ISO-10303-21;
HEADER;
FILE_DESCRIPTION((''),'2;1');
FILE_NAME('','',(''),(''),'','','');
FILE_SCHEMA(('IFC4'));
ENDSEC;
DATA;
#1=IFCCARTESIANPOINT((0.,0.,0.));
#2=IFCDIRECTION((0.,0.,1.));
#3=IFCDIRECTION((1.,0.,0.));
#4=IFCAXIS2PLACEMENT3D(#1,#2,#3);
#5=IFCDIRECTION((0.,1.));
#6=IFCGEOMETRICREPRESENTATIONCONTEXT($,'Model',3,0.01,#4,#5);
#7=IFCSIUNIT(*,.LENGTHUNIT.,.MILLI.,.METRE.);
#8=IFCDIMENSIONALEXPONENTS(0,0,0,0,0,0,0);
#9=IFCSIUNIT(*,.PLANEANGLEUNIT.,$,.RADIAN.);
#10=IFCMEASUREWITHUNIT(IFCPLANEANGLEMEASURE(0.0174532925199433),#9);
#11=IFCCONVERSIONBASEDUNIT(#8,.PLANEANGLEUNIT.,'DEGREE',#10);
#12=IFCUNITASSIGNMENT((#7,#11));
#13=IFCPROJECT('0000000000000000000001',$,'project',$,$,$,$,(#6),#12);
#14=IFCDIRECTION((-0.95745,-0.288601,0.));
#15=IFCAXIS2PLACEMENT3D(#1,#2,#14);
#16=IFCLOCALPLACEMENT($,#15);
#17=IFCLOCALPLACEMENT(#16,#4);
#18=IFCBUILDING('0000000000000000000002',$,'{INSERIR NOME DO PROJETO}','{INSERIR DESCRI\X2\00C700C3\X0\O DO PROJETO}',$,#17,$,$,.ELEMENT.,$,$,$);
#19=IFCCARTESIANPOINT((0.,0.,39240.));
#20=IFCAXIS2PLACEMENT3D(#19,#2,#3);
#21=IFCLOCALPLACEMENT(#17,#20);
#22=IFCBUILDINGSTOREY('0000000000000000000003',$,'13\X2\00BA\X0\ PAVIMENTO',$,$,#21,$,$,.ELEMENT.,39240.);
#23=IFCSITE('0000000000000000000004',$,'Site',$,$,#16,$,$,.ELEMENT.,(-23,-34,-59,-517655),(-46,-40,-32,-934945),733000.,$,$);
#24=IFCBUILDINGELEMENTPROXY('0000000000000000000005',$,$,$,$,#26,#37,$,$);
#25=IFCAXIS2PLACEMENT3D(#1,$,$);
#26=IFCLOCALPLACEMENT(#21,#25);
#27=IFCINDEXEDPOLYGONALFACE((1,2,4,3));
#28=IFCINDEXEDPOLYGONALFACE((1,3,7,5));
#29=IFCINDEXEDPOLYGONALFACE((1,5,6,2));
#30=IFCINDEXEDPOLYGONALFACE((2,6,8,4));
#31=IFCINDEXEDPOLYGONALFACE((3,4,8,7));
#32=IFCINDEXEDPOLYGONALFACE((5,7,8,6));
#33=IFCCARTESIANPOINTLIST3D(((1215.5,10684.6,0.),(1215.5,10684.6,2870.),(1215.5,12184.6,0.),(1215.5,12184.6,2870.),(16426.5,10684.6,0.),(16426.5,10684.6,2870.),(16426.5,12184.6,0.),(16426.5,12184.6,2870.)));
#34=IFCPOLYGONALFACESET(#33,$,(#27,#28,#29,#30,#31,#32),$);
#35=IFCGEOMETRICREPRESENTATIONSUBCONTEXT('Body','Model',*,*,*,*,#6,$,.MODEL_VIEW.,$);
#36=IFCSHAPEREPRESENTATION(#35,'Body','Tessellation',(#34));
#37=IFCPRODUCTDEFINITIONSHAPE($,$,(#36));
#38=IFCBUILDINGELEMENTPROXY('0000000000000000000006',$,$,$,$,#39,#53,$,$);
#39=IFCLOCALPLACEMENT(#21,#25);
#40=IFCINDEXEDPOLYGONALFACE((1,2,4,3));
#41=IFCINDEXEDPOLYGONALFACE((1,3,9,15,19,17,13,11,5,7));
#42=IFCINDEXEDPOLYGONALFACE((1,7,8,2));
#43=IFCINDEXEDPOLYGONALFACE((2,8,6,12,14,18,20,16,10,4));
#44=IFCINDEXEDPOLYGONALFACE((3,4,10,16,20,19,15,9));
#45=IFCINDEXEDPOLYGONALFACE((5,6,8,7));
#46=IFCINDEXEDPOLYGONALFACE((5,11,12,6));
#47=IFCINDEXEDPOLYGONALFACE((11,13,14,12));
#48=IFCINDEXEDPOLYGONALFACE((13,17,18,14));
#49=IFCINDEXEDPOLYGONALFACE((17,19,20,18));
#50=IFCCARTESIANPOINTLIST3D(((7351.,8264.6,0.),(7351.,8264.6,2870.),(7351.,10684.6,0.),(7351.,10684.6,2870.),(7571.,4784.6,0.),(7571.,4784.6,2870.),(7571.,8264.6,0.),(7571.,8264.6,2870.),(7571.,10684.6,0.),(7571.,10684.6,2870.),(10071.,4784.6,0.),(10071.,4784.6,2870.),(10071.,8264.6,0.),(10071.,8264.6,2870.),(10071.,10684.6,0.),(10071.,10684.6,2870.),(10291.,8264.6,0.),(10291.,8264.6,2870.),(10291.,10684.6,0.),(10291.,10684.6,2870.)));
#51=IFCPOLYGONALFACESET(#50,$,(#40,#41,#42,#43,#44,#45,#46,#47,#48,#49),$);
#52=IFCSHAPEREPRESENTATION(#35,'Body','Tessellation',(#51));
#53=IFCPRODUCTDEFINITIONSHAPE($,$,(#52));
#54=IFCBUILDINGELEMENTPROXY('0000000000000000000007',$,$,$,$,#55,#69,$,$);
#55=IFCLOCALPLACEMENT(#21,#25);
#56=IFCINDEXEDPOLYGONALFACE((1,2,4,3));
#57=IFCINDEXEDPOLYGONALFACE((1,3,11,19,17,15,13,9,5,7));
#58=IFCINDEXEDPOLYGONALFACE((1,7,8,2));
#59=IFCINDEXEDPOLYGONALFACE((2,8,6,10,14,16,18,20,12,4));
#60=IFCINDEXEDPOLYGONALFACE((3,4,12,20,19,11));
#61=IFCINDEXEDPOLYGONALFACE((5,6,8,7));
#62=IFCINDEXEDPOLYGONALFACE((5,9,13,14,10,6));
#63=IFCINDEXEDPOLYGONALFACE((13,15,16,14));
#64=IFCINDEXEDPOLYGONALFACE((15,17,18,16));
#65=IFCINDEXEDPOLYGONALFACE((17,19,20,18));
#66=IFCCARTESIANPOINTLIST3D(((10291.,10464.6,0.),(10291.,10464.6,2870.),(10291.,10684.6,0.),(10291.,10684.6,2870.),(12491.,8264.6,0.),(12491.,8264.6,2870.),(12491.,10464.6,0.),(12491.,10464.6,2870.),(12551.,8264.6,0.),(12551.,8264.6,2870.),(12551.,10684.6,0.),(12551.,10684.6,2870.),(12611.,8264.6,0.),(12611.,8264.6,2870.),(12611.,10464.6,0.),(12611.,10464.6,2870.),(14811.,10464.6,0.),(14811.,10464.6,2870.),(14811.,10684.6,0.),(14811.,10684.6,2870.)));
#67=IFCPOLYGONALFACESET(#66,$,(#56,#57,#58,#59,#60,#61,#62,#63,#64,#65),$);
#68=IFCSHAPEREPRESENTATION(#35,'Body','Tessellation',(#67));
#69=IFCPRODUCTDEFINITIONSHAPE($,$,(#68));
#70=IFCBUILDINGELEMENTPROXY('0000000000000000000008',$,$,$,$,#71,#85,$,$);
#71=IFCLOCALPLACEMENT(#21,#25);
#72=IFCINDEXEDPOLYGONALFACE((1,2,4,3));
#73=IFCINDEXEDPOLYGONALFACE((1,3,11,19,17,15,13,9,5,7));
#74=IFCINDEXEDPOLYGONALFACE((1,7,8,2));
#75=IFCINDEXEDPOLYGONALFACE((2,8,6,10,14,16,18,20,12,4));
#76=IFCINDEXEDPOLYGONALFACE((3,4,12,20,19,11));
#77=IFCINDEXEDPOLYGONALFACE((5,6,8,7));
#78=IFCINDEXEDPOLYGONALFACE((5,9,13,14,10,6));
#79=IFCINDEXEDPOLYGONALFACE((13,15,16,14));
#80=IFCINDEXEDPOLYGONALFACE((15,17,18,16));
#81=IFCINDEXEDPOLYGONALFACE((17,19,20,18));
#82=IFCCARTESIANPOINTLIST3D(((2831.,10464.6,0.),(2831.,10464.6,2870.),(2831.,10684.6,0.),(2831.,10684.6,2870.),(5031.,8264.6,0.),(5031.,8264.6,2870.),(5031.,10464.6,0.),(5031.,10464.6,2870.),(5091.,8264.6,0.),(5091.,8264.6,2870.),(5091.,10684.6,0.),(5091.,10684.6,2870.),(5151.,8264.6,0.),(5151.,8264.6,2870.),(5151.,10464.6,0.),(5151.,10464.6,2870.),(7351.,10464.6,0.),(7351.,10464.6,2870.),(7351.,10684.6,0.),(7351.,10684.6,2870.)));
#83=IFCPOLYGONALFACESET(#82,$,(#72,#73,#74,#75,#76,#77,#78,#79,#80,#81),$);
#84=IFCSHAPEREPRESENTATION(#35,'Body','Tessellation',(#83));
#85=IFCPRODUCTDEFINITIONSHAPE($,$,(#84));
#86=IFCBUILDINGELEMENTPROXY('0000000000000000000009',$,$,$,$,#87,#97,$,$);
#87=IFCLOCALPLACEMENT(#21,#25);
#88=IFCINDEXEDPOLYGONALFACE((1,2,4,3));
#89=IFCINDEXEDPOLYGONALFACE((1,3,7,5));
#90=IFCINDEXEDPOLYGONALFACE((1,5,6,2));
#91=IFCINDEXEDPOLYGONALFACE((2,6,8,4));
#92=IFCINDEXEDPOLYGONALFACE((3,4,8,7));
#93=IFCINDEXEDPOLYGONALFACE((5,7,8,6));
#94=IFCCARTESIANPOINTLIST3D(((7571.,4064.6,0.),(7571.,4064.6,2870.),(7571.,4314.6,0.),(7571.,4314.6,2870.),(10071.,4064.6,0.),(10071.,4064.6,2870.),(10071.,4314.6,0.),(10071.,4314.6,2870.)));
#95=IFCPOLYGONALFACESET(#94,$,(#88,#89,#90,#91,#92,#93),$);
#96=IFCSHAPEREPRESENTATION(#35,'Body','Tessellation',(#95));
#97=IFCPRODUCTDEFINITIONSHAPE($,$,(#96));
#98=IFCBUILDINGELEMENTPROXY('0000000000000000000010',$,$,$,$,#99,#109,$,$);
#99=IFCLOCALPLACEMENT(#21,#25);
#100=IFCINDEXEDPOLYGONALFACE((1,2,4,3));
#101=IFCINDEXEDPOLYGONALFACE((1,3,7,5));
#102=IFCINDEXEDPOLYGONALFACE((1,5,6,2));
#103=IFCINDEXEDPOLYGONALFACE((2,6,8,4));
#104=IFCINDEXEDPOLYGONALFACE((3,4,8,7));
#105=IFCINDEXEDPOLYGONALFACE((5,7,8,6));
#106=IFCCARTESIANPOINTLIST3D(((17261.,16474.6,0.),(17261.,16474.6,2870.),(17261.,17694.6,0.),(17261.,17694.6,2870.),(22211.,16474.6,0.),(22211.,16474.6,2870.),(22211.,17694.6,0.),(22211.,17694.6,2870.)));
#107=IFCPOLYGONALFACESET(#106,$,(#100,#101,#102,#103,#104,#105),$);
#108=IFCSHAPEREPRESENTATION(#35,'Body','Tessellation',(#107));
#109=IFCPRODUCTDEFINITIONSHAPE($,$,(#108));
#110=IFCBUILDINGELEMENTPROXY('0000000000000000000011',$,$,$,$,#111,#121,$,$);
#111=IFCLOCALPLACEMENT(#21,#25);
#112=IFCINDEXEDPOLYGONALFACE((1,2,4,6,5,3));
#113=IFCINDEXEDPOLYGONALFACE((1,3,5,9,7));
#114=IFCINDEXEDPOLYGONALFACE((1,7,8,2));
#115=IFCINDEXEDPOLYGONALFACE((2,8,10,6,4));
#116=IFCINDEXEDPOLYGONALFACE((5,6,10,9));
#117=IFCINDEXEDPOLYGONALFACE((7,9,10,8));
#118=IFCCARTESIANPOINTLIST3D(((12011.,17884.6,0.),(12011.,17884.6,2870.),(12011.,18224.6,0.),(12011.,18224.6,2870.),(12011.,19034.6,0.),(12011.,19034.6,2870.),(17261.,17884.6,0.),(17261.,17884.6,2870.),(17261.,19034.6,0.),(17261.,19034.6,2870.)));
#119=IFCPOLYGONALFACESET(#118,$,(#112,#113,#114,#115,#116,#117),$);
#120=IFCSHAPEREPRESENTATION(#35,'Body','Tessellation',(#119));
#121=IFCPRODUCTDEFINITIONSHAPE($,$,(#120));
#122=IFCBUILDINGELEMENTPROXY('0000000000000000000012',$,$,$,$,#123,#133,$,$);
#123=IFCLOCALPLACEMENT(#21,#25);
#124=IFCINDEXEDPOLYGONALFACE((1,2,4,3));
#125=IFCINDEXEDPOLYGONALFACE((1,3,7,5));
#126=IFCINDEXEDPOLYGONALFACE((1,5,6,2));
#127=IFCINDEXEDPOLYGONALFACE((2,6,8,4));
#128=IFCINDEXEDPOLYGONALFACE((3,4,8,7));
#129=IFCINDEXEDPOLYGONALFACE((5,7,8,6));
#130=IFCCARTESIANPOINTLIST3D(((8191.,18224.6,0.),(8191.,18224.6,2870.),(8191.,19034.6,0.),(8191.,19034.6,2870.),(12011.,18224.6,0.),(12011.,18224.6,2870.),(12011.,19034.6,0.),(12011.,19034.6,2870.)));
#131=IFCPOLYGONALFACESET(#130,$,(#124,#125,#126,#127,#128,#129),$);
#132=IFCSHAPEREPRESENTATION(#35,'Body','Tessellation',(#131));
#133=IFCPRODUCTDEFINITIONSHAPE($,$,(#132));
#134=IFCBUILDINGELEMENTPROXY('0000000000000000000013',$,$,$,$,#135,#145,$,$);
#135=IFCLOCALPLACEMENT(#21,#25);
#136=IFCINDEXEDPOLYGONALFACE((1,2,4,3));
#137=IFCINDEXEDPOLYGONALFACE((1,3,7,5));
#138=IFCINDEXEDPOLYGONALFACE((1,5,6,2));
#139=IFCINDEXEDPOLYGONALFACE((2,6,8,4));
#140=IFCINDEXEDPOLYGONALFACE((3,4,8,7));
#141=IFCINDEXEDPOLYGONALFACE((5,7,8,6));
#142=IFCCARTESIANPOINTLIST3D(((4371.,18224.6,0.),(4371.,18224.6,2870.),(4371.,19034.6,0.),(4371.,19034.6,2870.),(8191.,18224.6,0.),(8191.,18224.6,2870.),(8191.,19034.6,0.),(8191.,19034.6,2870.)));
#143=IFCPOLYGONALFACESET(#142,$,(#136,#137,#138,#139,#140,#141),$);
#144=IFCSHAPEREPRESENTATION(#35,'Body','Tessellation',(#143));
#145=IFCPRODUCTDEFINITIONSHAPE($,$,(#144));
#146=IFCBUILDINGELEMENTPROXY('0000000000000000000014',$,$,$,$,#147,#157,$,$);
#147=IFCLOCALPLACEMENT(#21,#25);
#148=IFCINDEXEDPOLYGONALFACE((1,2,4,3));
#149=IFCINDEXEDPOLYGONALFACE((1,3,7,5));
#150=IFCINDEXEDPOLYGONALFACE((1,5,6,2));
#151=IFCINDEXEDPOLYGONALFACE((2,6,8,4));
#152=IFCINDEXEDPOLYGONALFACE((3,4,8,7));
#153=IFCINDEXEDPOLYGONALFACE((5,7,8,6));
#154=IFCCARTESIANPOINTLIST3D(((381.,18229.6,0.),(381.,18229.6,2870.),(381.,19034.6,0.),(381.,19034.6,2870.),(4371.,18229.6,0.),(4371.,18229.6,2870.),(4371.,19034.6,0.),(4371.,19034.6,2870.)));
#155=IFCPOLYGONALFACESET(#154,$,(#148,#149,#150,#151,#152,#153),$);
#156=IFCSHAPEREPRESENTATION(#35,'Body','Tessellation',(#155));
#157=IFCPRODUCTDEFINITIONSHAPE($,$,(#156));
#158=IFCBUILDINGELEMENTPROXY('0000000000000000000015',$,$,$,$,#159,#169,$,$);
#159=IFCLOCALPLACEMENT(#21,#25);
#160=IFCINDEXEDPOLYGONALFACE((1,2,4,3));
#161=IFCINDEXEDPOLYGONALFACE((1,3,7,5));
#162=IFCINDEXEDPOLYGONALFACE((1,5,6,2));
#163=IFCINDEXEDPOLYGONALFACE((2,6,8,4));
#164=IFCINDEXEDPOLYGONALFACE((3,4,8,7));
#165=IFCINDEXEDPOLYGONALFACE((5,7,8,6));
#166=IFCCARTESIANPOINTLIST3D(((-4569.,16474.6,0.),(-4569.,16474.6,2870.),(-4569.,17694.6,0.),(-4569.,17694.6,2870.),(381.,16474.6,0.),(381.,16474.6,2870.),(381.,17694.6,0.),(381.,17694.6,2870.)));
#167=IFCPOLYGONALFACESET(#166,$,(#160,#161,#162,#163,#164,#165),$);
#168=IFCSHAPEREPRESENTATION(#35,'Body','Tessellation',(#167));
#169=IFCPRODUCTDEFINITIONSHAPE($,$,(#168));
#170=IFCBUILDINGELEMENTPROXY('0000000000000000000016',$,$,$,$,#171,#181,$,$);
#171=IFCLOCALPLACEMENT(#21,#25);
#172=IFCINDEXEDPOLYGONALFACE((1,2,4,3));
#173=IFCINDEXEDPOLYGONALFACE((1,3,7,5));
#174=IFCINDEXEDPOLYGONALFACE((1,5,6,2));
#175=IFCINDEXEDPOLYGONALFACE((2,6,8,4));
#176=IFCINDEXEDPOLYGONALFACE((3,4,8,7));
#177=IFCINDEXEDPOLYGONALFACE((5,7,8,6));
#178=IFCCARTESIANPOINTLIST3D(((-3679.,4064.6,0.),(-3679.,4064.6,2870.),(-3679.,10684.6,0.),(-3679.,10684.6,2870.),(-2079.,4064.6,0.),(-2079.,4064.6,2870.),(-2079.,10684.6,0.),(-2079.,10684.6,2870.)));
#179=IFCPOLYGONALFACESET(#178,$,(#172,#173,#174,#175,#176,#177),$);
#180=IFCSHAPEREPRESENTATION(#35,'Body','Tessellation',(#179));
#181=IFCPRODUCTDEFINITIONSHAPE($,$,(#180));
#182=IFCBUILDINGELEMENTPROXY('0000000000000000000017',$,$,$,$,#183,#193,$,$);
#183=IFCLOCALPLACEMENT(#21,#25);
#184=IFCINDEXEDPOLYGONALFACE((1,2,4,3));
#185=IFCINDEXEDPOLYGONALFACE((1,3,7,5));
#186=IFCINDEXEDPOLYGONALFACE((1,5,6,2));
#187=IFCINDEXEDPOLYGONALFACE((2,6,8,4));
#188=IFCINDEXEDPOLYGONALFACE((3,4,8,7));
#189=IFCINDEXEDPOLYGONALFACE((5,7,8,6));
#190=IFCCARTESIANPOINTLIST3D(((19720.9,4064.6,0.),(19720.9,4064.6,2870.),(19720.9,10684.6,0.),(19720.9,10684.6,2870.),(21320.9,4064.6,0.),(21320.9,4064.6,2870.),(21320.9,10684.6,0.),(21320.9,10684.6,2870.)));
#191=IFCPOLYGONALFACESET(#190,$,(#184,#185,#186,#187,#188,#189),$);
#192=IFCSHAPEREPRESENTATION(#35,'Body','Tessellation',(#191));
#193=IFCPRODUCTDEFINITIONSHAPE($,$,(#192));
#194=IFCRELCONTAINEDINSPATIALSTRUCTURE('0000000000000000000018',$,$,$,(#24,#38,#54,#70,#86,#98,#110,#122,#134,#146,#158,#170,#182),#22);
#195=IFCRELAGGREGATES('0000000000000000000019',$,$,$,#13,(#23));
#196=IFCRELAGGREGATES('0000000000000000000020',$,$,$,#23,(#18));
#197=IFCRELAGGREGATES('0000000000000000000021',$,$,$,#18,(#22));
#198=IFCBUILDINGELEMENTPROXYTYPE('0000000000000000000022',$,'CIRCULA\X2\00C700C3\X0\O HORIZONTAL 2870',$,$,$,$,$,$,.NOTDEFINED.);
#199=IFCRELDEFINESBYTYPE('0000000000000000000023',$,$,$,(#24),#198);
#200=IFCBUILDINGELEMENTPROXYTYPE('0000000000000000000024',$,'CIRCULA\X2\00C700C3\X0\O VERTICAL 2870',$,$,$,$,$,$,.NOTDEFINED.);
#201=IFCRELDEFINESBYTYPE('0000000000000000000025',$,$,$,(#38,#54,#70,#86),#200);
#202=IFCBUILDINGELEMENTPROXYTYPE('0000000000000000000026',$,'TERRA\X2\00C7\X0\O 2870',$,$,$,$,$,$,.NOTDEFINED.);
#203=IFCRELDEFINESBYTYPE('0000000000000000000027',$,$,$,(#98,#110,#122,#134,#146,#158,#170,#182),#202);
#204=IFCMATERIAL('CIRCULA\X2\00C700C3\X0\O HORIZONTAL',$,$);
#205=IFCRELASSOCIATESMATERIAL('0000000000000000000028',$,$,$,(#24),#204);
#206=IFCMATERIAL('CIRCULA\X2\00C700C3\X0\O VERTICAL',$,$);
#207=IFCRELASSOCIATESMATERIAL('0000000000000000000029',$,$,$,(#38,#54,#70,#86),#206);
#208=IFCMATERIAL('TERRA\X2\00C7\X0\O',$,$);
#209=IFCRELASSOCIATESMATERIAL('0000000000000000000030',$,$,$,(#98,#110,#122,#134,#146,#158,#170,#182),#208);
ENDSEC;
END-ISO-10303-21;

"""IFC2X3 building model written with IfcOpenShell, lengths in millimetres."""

from ifc_helpers import new_model, entity, si_unit, converted_unit, direction, frame, origin_with_axes, place, context, subcontext, project, spatial, polyline, outline, extrude, material, type_object, element, save


model = new_model("IFC2X3")

# Units and contexts
model_context = context("Model", 3, precision=0.01, world=origin_with_axes(), true_north=direction((0.0, 1.0)))
body_context = subcontext(model_context, "Body", "Model", "MODEL_VIEW")
ifc_project = project(units=[si_unit("LENGTHUNIT", "METRE", prefix="MILLI"), converted_unit("PLANEANGLEUNIT", "DEGREE", entity("IfcPlaneAngleMeasure", 0.0174532925199433), si_unit("PLANEANGLEUNIT", "RADIAN"), dimensions=[0, 0, 0, 0, 0, 0, 0])], contexts=[model_context])

# Site, building, storey
site_placement = place(None, frame((0.0, 0.0, 0.0), z_axis=(0.0, 0.0, 1.0), x_axis=(-0.95745, -0.288601, 0.0)))
site = spatial("IfcSite", under=ifc_project, at=site_placement, Name="Site", CompositionType="ELEMENT", RefLatitude=(-23, -34, -59, -517655), RefLongitude=(-46, -40, -32, -934945), RefElevation=733000.0)
building_placement = place(site_placement, origin_with_axes())
building = spatial("IfcBuilding", under=site, at=building_placement, Name="{INSERIR NOME DO PROJETO}", Description="{INSERIR DESCRIÇÃO DO PROJETO}", CompositionType="ELEMENT")
storey_placement = place(building_placement, frame((0.0, 0.0, 39240.0), z_axis=(0.0, 0.0, 1.0), x_axis=(1.0, 0.0, 0.0)))
storey = spatial("IfcBuildingStorey", under=building, at=storey_placement, Name="13º PAVIMENTO", CompositionType="ELEMENT", Elevation=39240.0)

# Building element proxies
ifc_material_1 = material(Name="CIRCULAÇÃO HORIZONTAL")
building_element_proxy_type_1 = type_object("IfcBuildingElementProxyType", Name="CIRCULAÇÃO HORIZONTAL 2870", PredefinedType="NOTDEFINED")
proxy_1_placement = place(storey_placement, frame((1215.5, 10684.6, 0.0), z_axis=(0.0, 0.0, 1.0), x_axis=(1.0, 0.0, 0.0)))
element("IfcBuildingElementProxy", 1, at=proxy_1_placement, inside=storey, type_object=building_element_proxy_type_1, material=ifc_material_1, context=body_context, shape_type="SweptSolid", body=[
    extrude(outline(polyline([(0.0, 0.0), (15211.0, 0.0), (15211.0, 1500.0), (0.0, 1500.0), (0.0, 0.0)])), origin_with_axes(), (0.0, 0.0, 1.0), 2870.0),
])
ifc_material_2 = material(Name="CIRCULAÇÃO VERTICAL")
building_element_proxy_type_2 = type_object("IfcBuildingElementProxyType", Name="CIRCULAÇÃO VERTICAL 2870", PredefinedType="NOTDEFINED")
proxy_2_placement = place(storey_placement, frame((7351.0, 10684.6, 0.0), z_axis=(0.0, 0.0, 1.0), x_axis=(1.0, 0.0, 0.0)))
element("IfcBuildingElementProxy", 2, at=proxy_2_placement, inside=storey, type_object=building_element_proxy_type_2, material=ifc_material_2, context=body_context, shape_type="SweptSolid", body=[
    extrude(outline(polyline([(0.0, 0.0), (0.0, -2420.0), (220.0, -2420.0), (220.0, -5900.0), (2720.0, -5900.0), (2720.0, -2420.0), (2940.0, -2420.0), (2940.0, 0.0), (2720.0, 0.0), (220.0, 0.0), (0.0, 0.0)])), origin_with_axes(), (0.0, 0.0, 1.0), 2870.0),
])
proxy_3_placement = place(storey_placement, frame((10291.0, 10684.6, 0.0), z_axis=(0.0, 0.0, 1.0), x_axis=(1.0, 0.0, 0.0)))
element("IfcBuildingElementProxy", 3, at=proxy_3_placement, inside=storey, type_object=building_element_proxy_type_2, material=ifc_material_2, context=body_context, shape_type="SweptSolid", body=[
    extrude(outline(polyline([(0.0, 0.0), (0.0, -220.0), (2200.0, -220.0), (2200.0, -2420.0), (2260.0, -2420.0), (2320.0, -2420.0), (2320.0, -220.0), (4520.0, -220.0), (4520.0, 0.0), (2260.0, 0.0), (0.0, 0.0)])), origin_with_axes(), (0.0, 0.0, 1.0), 2870.0),
])
proxy_4_placement = place(storey_placement, frame((5091.0, 10684.6, 0.0), z_axis=(0.0, 0.0, 1.0), x_axis=(1.0, 0.0, 0.0)))
element("IfcBuildingElementProxy", 4, at=proxy_4_placement, inside=storey, type_object=building_element_proxy_type_2, material=ifc_material_2, context=body_context, shape_type="SweptSolid", body=[
    extrude(outline(polyline([(0.0, 0.0), (-2260.0, 0.0), (-2260.0, -220.0), (-60.0, -220.0), (-60.0, -2420.0), (0.0, -2420.0), (60.0, -2420.0), (60.0, -220.0), (2260.0, -220.0), (2260.0, 0.0), (0.0, 0.0)])), origin_with_axes(), (0.0, 0.0, 1.0), 2870.0),
])
proxy_5_placement = place(storey_placement, frame((7571.0, 4064.6, 0.0), z_axis=(0.0, 0.0, 1.0), x_axis=(1.0, 0.0, 0.0)))
element("IfcBuildingElementProxy", 5, at=proxy_5_placement, inside=storey, type_object=building_element_proxy_type_2, material=ifc_material_2, context=body_context, shape_type="SweptSolid", body=[
    extrude(outline(polyline([(0.0, 0.0), (2500.0, 0.0), (2500.0, 250.0), (0.0, 250.0), (0.0, 0.0)])), origin_with_axes(), (0.0, 0.0, 1.0), 2870.0),
])
ifc_material_3 = material(Name="TERRAÇO")
building_element_proxy_type_3 = type_object("IfcBuildingElementProxyType", Name="TERRAÇO 2870", PredefinedType="NOTDEFINED")
proxy_6_placement = place(storey_placement, frame((17261.0, 16474.6, 0.0), z_axis=(0.0, 0.0, 1.0), x_axis=(1.0, 0.0, 0.0)))
element("IfcBuildingElementProxy", 6, at=proxy_6_placement, inside=storey, type_object=building_element_proxy_type_3, material=ifc_material_3, context=body_context, shape_type="SweptSolid", body=[
    extrude(outline(polyline([(0.0, 0.0), (4950.0, 0.0), (4950.0, 1220.0), (0.0, 1220.0), (0.0, 0.0)])), origin_with_axes(), (0.0, 0.0, 1.0), 2870.0),
])
proxy_7_placement = place(storey_placement, frame((12011.0, 19034.6, 0.0), z_axis=(0.0, 0.0, 1.0), x_axis=(1.0, 0.0, 0.0)))
element("IfcBuildingElementProxy", 7, at=proxy_7_placement, inside=storey, type_object=building_element_proxy_type_3, material=ifc_material_3, context=body_context, shape_type="SweptSolid", body=[
    extrude(outline(polyline([(0.0, 0.0), (0.0, -810.0), (0.0, -1150.0), (5250.0, -1150.0), (5250.0, 0.0), (0.0, 0.0)])), origin_with_axes(), (0.0, 0.0, 1.0), 2870.0),
])
for number, where, z_axis, x_axis in (
    (8, (8191.0, 18224.6, 0.0), (0.0, 0.0, 1.0), (1.0, 0.0, 0.0)),
    (9, (4371.0, 18224.6, 0.0), (0.0, 0.0, 1.0), (1.0, 0.0, 0.0)),
):
    element("IfcBuildingElementProxy", number, at=place(storey_placement, frame(where, z_axis=z_axis, x_axis=x_axis)), inside=storey, type_object=building_element_proxy_type_3, material=ifc_material_3, context=body_context, shape_type="SweptSolid", body=[
        extrude(outline(polyline([(0.0, 0.0), (3820.0, 0.0), (3820.0, 810.0), (0.0, 810.0), (0.0, 0.0)])), origin_with_axes(), (0.0, 0.0, 1.0), 2870.0),
    ])
proxy_8_placement = place(storey_placement, frame((381.0, 19034.6, 0.0), z_axis=(0.0, 0.0, 1.0), x_axis=(1.0, 0.0, 0.0)))
element("IfcBuildingElementProxy", 10, at=proxy_8_placement, inside=storey, type_object=building_element_proxy_type_3, material=ifc_material_3, context=body_context, shape_type="SweptSolid", body=[
    extrude(outline(polyline([(0.0, 0.0), (0.0, -805.0), (3990.0, -805.0), (3990.0, 0.0), (0.0, 0.0)])), origin_with_axes(), (0.0, 0.0, 1.0), 2870.0),
])
proxy_9_placement = place(storey_placement, frame((381.0, 17694.6, 0.0), z_axis=(0.0, 0.0, 1.0), x_axis=(1.0, 0.0, 0.0)))
element("IfcBuildingElementProxy", 11, at=proxy_9_placement, inside=storey, type_object=building_element_proxy_type_3, material=ifc_material_3, context=body_context, shape_type="SweptSolid", body=[
    extrude(outline(polyline([(0.0, 0.0), (-4950.0, 0.0), (-4950.0, -1220.0), (0.0, -1220.0), (0.0, 0.0)])), origin_with_axes(), (0.0, 0.0, 1.0), 2870.0),
])
proxy_10_placement = place(storey_placement, frame((-3679.0, 4064.6, 0.0), z_axis=(0.0, 0.0, 1.0), x_axis=(1.0, 0.0, 0.0)))
element("IfcBuildingElementProxy", 12, at=proxy_10_placement, inside=storey, type_object=building_element_proxy_type_3, material=ifc_material_3, context=body_context, shape_type="SweptSolid", body=[
    extrude(outline(polyline([(0.0, 0.0), (1600.0, 0.0), (1600.0, 6620.0), (0.0, 6620.0), (0.0, 0.0)])), origin_with_axes(), (0.0, 0.0, 1.0), 2870.0),
])
proxy_11_placement = place(storey_placement, frame((21320.9, 4064.6, 0.0), z_axis=(0.0, 0.0, 1.0), x_axis=(1.0, 0.0, 0.0)))
element("IfcBuildingElementProxy", 13, at=proxy_11_placement, inside=storey, type_object=building_element_proxy_type_3, material=ifc_material_3, context=body_context, shape_type="SweptSolid", body=[
    extrude(outline(polyline([(0.0, 0.0), (0.0, 6620.0), (-1600.0, 6620.0), (-1600.0, 0.0), (0.0, 0.0)])), origin_with_axes(), (0.0, 0.0, 1.0), 2870.0),
])

save(model, "model.ifc")
